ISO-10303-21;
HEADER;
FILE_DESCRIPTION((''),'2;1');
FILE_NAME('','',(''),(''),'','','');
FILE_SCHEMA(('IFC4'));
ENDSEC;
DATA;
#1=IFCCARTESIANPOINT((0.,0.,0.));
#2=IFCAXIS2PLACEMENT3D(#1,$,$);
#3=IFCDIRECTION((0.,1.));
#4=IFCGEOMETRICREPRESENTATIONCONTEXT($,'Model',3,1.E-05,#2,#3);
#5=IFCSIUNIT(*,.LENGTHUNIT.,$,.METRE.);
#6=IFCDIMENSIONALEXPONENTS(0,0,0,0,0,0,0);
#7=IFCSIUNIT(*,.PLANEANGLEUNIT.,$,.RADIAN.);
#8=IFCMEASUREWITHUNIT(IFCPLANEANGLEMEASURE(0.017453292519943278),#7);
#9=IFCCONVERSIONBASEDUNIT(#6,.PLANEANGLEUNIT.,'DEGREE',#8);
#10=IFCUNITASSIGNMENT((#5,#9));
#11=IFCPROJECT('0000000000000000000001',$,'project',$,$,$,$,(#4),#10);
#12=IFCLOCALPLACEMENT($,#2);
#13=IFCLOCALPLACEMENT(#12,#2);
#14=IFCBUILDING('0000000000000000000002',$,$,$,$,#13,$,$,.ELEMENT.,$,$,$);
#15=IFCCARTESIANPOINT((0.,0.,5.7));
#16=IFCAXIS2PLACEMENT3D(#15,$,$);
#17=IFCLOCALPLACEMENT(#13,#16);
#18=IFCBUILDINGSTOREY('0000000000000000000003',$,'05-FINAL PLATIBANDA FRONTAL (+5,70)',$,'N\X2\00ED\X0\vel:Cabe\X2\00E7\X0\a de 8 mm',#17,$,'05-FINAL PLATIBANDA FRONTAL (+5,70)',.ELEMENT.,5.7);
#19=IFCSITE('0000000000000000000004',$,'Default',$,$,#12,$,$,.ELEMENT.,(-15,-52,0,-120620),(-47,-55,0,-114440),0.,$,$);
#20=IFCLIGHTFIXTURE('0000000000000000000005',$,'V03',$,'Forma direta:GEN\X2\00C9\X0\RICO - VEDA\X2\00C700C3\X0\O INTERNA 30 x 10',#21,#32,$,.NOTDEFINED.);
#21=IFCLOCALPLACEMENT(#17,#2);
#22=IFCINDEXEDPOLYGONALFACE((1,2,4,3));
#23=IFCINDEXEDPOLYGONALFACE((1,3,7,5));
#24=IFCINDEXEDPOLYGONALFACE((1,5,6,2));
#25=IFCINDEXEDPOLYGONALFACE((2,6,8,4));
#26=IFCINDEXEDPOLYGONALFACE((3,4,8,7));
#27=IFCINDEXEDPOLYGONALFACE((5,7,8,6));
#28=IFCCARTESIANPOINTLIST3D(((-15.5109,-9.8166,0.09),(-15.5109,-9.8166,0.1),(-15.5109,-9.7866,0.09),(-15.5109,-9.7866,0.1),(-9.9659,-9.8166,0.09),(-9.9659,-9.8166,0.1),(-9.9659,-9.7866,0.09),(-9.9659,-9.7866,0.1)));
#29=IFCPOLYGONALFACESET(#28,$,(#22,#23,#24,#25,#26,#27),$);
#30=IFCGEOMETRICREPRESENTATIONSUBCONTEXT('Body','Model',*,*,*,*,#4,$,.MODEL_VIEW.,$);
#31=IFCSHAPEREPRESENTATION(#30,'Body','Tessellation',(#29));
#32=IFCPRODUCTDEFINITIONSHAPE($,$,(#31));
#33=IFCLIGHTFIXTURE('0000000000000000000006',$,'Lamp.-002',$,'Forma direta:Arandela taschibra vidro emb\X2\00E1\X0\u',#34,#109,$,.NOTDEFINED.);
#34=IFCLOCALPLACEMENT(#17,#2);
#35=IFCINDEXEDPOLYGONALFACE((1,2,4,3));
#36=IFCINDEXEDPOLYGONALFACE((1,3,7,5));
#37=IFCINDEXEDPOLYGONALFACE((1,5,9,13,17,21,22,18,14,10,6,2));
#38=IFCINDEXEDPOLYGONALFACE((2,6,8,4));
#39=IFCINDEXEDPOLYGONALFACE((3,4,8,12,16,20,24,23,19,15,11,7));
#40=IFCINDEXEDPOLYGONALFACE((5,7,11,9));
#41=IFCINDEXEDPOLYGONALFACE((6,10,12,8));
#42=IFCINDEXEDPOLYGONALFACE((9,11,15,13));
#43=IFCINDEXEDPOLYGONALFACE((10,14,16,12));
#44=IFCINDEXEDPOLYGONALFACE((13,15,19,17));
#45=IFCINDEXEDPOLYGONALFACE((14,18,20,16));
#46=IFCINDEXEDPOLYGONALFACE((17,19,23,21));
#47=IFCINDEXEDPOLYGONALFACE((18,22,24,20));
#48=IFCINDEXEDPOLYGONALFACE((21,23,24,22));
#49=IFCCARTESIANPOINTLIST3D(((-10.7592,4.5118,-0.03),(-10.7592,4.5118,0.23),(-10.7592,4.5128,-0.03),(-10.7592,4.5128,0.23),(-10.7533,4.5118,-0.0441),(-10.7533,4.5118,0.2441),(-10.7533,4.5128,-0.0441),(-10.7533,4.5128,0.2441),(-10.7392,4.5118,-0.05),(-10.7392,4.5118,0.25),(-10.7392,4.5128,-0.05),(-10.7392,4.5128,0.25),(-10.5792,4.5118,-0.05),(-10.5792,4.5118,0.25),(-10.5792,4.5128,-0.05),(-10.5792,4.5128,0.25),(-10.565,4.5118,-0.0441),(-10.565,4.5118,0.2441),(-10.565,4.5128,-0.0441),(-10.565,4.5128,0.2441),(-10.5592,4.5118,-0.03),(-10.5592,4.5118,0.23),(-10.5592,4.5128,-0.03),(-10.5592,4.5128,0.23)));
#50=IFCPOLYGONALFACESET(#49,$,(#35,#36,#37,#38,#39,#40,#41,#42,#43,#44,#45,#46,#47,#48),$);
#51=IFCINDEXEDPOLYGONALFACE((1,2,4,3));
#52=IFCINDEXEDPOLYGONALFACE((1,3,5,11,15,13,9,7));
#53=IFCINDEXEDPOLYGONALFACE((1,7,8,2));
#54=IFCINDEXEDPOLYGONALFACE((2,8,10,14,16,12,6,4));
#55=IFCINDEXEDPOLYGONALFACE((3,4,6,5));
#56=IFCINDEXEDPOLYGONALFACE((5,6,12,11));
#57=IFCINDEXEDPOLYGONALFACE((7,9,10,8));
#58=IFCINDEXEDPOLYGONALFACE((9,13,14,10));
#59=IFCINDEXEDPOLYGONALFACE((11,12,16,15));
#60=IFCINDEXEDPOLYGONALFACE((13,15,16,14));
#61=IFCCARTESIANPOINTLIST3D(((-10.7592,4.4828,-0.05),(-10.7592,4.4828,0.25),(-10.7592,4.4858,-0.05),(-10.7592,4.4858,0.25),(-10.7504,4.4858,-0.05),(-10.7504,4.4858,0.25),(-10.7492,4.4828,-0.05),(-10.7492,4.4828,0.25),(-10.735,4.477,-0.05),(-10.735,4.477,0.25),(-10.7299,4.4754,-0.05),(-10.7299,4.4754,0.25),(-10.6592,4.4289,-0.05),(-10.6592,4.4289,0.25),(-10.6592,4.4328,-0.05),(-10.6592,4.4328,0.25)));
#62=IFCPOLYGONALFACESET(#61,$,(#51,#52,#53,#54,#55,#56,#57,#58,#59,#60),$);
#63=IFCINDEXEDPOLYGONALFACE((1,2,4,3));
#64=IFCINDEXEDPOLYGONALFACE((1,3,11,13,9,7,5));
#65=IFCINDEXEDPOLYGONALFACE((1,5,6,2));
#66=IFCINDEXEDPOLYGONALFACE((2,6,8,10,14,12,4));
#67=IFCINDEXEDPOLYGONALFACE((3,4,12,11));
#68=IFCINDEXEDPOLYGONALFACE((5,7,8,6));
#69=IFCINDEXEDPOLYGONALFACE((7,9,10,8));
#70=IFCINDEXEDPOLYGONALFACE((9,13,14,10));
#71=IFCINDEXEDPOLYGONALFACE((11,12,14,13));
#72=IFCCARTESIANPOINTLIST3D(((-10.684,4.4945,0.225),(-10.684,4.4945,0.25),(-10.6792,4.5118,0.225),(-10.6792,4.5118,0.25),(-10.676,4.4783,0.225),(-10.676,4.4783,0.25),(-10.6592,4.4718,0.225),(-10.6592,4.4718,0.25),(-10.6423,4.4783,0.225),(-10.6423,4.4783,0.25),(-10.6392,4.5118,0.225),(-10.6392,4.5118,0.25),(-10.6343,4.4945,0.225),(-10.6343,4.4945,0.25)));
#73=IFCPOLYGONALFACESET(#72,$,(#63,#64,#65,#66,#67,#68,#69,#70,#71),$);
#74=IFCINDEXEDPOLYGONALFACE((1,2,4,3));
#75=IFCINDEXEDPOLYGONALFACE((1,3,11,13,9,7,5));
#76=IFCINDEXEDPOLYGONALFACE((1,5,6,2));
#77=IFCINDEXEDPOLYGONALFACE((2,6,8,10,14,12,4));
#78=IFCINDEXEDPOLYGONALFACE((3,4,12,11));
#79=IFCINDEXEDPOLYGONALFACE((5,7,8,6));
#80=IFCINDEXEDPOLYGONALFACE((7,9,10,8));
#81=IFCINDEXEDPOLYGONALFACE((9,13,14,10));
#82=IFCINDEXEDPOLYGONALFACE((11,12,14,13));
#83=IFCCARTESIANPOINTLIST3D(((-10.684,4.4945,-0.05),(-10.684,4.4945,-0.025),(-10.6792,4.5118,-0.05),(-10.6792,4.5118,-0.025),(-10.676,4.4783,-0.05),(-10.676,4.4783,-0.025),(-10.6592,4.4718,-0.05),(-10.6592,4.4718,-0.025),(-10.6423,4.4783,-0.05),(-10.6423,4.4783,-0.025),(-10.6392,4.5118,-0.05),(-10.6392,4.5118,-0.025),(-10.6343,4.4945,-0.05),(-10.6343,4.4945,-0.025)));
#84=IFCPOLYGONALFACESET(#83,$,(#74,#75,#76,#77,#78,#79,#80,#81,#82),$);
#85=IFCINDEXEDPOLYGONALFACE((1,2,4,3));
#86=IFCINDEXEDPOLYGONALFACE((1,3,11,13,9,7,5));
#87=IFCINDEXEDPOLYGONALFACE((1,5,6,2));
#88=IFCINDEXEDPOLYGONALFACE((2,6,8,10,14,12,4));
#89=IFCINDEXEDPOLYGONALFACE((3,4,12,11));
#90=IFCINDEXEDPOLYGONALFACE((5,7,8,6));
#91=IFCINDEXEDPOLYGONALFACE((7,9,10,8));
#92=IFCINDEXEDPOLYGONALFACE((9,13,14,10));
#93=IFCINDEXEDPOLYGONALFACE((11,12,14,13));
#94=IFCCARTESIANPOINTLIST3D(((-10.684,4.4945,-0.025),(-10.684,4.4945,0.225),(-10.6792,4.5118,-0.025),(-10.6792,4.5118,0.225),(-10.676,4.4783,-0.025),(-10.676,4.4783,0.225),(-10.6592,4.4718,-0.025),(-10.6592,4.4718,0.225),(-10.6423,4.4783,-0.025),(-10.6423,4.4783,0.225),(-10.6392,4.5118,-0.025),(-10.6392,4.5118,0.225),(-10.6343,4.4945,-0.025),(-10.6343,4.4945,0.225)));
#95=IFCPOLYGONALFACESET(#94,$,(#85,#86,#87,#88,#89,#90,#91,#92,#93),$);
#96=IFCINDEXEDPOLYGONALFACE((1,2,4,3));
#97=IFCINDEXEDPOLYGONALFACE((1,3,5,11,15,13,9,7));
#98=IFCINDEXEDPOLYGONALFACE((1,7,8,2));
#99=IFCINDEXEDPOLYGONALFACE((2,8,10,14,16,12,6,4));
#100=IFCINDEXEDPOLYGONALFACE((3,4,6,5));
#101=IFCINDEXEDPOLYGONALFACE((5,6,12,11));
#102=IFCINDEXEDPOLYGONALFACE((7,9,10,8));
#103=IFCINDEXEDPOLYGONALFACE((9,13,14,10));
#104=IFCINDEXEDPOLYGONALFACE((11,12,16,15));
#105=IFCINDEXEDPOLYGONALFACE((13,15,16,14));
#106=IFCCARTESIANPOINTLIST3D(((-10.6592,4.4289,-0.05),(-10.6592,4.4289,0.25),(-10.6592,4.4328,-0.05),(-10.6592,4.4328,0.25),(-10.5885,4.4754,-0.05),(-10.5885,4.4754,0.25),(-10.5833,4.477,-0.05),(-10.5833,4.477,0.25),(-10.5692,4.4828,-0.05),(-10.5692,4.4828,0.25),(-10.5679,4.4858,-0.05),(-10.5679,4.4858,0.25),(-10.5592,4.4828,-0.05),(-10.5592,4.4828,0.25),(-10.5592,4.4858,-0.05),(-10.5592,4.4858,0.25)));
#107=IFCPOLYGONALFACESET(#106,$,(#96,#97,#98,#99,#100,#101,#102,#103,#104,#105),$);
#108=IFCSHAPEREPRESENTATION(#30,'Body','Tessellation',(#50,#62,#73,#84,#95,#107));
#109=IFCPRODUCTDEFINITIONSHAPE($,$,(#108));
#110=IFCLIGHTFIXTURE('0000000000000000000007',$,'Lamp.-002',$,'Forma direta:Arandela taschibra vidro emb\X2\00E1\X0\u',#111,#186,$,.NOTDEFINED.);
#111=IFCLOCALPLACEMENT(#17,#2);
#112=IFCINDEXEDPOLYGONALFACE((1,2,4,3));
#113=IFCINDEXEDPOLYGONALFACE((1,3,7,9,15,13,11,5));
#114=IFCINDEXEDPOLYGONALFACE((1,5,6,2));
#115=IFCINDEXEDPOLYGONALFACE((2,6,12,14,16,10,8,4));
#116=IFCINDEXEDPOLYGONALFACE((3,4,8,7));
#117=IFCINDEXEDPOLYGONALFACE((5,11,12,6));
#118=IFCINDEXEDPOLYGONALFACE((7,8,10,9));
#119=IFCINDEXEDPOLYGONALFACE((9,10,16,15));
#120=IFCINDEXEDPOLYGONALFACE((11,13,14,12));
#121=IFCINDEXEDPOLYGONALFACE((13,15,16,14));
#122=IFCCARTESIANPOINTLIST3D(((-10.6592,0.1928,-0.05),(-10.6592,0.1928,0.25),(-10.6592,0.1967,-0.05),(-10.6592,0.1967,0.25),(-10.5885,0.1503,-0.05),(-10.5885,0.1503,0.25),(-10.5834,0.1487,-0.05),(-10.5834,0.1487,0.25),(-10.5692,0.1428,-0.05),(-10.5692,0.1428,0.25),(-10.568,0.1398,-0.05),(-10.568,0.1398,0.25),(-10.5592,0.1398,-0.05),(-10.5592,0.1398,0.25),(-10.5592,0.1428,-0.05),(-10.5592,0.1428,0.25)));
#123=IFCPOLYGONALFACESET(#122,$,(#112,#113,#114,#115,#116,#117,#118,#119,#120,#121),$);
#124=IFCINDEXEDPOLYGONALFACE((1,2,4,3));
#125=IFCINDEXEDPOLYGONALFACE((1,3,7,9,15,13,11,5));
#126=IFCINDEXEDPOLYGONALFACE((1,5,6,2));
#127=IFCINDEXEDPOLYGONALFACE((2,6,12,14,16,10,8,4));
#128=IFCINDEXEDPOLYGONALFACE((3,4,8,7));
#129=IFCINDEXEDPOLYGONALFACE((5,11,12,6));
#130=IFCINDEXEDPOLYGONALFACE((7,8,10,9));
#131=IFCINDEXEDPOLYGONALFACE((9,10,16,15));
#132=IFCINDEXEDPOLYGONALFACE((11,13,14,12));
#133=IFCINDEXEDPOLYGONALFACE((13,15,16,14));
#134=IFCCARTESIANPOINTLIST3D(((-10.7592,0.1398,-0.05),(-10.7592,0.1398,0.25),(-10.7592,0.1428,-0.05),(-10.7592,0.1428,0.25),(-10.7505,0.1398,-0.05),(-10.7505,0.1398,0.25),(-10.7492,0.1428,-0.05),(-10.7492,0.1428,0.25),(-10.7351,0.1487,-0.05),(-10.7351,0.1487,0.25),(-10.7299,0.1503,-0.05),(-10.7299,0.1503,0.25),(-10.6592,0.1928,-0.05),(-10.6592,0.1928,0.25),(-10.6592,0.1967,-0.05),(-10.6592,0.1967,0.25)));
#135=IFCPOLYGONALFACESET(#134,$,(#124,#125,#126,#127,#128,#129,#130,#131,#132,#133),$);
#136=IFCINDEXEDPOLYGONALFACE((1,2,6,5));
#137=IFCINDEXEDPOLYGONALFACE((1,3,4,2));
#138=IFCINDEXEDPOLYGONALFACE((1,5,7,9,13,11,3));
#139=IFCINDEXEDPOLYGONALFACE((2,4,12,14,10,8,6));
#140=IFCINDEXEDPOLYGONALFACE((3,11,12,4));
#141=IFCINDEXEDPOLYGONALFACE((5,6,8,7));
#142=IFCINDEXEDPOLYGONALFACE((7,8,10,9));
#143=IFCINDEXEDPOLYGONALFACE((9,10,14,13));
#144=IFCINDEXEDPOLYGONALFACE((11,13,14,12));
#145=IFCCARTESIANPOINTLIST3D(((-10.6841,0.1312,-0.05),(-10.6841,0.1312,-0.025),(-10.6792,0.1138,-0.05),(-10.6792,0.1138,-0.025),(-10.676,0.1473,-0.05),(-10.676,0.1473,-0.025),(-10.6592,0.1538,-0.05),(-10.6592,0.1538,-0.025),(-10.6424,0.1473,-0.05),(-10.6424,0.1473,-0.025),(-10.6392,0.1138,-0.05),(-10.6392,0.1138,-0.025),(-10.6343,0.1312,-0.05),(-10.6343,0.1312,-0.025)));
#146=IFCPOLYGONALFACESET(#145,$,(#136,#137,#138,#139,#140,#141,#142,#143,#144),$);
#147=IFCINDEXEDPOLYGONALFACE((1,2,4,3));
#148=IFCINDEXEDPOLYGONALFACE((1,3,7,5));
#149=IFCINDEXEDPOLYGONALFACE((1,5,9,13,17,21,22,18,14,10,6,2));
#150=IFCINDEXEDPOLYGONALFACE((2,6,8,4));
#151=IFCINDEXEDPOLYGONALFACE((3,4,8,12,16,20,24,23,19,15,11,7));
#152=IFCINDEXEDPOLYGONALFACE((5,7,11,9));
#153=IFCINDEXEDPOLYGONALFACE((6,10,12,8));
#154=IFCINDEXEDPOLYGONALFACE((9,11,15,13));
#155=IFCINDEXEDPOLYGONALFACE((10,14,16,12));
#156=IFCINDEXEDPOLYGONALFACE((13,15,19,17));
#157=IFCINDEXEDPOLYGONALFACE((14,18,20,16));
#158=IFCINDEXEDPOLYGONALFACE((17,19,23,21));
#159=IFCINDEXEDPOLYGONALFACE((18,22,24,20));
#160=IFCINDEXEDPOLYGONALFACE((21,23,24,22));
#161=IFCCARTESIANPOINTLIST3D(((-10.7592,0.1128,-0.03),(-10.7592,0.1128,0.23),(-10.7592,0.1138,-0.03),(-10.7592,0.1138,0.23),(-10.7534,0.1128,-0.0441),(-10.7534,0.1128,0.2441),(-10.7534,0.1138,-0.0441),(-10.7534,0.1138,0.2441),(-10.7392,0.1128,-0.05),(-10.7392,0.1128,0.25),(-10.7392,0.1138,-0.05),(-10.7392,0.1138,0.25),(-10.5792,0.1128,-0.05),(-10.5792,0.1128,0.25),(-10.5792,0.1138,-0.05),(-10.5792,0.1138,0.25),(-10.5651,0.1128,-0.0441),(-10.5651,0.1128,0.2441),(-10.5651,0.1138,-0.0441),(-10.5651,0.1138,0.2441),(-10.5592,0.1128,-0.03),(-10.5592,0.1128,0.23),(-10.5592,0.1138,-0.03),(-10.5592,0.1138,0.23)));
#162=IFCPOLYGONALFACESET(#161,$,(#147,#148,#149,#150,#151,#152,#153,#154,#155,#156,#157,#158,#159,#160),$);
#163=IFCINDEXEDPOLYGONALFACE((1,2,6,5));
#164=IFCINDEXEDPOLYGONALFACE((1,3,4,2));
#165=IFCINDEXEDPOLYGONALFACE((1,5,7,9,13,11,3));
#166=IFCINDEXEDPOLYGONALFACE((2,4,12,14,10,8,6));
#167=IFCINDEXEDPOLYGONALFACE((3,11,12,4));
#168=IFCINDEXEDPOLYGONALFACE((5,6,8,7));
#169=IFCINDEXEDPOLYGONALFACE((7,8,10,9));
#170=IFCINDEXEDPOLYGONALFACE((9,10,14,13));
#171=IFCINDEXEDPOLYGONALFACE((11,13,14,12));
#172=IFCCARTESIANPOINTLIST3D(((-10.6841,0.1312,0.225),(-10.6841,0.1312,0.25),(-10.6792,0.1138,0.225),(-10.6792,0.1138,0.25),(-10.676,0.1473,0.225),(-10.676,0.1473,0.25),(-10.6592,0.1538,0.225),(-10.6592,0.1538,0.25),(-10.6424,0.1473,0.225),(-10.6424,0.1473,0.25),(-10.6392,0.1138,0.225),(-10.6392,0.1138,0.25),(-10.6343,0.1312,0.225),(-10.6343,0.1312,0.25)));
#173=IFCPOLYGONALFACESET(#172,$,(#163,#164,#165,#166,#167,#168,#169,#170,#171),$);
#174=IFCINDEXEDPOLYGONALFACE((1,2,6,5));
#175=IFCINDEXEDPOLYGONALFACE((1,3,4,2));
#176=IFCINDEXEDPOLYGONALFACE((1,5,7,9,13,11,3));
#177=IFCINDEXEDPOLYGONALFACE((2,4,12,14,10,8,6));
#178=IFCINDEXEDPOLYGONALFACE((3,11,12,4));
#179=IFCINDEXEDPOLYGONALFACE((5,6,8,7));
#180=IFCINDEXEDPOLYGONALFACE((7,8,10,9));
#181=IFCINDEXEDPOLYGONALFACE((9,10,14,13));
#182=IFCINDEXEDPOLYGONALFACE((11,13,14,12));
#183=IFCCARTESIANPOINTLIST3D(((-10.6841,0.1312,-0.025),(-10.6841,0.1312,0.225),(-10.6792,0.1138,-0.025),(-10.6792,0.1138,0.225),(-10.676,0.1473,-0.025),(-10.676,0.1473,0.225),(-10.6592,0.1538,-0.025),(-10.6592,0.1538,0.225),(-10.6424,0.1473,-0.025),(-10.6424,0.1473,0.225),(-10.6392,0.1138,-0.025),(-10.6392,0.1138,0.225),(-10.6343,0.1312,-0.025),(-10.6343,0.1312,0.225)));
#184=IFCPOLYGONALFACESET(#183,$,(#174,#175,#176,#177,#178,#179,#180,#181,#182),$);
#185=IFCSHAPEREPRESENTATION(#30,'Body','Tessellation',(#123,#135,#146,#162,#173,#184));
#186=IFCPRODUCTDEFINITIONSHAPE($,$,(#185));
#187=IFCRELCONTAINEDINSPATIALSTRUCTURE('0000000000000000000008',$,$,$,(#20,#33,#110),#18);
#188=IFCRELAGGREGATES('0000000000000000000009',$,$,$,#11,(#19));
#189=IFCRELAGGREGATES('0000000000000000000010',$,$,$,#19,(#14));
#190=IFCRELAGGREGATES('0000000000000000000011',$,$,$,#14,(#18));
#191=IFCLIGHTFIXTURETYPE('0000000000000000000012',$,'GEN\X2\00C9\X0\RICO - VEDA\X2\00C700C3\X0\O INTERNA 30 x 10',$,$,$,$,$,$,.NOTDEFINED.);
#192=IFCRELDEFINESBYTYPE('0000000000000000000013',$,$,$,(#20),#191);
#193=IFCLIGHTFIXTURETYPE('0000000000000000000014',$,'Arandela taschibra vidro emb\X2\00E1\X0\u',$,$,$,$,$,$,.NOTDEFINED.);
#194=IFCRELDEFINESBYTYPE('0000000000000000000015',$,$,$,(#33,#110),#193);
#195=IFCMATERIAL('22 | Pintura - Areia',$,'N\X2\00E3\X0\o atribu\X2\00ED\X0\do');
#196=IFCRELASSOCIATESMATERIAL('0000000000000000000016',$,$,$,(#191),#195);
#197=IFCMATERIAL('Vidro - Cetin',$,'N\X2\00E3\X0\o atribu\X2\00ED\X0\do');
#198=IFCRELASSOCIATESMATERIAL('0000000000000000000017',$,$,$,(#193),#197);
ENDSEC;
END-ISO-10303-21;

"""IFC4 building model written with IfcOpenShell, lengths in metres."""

from ifc_helpers import new_model, entity, si_unit, converted_unit, direction, frame, origin, place, context, subcontext, project, spatial, indexed_curve, outline, extrude, material, type_object, element, save


model = new_model("IFC4")

# Units and contexts
model_context = context("Model", 3, precision=1e-05, world=origin(), true_north=direction((0.0, 1.0)))
body_context = subcontext(model_context, "Body", "Model", "MODEL_VIEW")
ifc_project = project(units=[si_unit("LENGTHUNIT", "METRE"), converted_unit("PLANEANGLEUNIT", "DEGREE", entity("IfcPlaneAngleMeasure", 0.017453292519943278), si_unit("PLANEANGLEUNIT", "RADIAN"), dimensions=[0, 0, 0, 0, 0, 0, 0])], contexts=[model_context])

# Site, building, storey
site_placement = place(None, origin())
site = spatial("IfcSite", under=ifc_project, at=site_placement, Name="Default", CompositionType="ELEMENT", RefLatitude=(-15, -52, 0, -120620), RefLongitude=(-47, -55, 0, -114440), RefElevation=0.0)
building_placement = place(site_placement, origin())
building = spatial("IfcBuilding", under=site, at=building_placement, CompositionType="ELEMENT")
storey_placement = place(building_placement, frame((0.0, 0.0, 5.7)))
storey = spatial("IfcBuildingStorey", under=building, at=storey_placement, Name="05-FINAL PLATIBANDA FRONTAL (+5,70)", ObjectType="Nível:Cabeça de 8 mm", LongName="05-FINAL PLATIBANDA FRONTAL (+5,70)", CompositionType="ELEMENT", Elevation=5.7)

# Light fixtures
ifc_material_1 = material(Name="22 | Pintura - Areia", Category="Não atribuído")
light_fixture_type_1 = type_object("IfcLightFixtureType", Name="GENÉRICO - VEDAÇÃO INTERNA 30 x 10", PredefinedType="NOTDEFINED", material=ifc_material_1)
light_fixture_1_placement = place(storey_placement, origin())
element("IfcLightFixture", 1, at=light_fixture_1_placement, inside=storey, type_object=light_fixture_type_1, Name="V03", ObjectType="Forma direta:GENÉRICO - VEDAÇÃO INTERNA 30 x 10", PredefinedType="NOTDEFINED", context=body_context, shape_type="SweptSolid", body=[
    extrude(outline(indexed_curve([(-2.7725, -0.015), (2.7725, -0.015), (2.7725, 0.015), (-2.7725, 0.015), (-2.7725, -0.015)], self_intersect=False)), frame((-12.7384, -9.8016, 0.09)), (0.0, 0.0, 1.0), 0.01),
])
ifc_material_2 = material(Name="Vidro - Cetin", Category="Não atribuído")
light_fixture_type_2 = type_object("IfcLightFixtureType", Name="Arandela taschibra vidro embáu", PredefinedType="NOTDEFINED", material=ifc_material_2)
light_fixture_2_placement = place(storey_placement, origin())
element("IfcLightFixture", 2, at=light_fixture_2_placement, inside=storey, type_object=light_fixture_type_2, Name="Lamp.-002", ObjectType="Forma direta:Arandela taschibra vidro embáu", PredefinedType="NOTDEFINED", context=body_context, shape_type="SweptSolid", body=[
    extrude(outline(indexed_curve([(-0.08, -0.15), (0.08, -0.15), (0.0941, -0.1441), (0.1, -0.13), (0.1, 0.13), (0.0941, 0.1441), (0.08, 0.15), (-0.08, 0.15), (-0.0941, 0.1441), (-0.1, 0.13), (-0.1, -0.13), (-0.0941, -0.1441), (-0.08, -0.15)], self_intersect=False)), frame((-10.6592, 4.5118, 0.1), z_axis=(0.000013, 1.0, 0.0), x_axis=(-1.0, 0.000013, 0.0)), (0.0, 0.0, 1.0), 0.001),
    extrude(outline(indexed_curve([(-0.0169, -0.034), (-0.0139, -0.034), (-0.0139, -0.024), (-0.008, -0.0099), (0.04, 0.066), (0.0361, 0.066), (-0.0065, -0.0047), (-0.0169, -0.0253), (-0.0169, -0.034)], self_intersect=False)), frame((-10.7251, 4.4689, -0.05), z_axis=(0.0, 0.0, 1.0), x_axis=(-0.000013, -1.0, 0.0)), (0.0, 0.0, 1.0), 0.3),
    extrude(outline(indexed_curve([(-0.0141, -0.0247), (0.004, -0.0247), (0.0173, -0.0126), (0.019, 0.0054), (0.0082, 0.0198), (-0.0095, 0.0232), (-0.0249, 0.0138), (-0.0141, -0.0247)], self_intersect=False)), frame((-10.6592, 4.4916, 0.225), z_axis=(0.0, 0.0, 1.0), x_axis=(-0.271031, -0.96257, 0.0)), (0.0, 0.0, 1.0), 0.025),
    extrude(outline(indexed_curve([(-0.0141, -0.0247), (0.004, -0.0247), (0.0173, -0.0126), (0.019, 0.0054), (0.0082, 0.0198), (-0.0095, 0.0232), (-0.0249, 0.0138), (-0.0141, -0.0247)], self_intersect=False)), frame((-10.6592, 4.4916, -0.05), z_axis=(0.0, 0.0, 1.0), x_axis=(-0.271031, -0.96257, 0.0)), (0.0, 0.0, 1.0), 0.025),
    extrude(outline(indexed_curve([(-0.0141, -0.0247), (0.004, -0.0247), (0.0173, -0.0126), (0.019, 0.0054), (0.0082, 0.0198), (-0.0095, 0.0232), (-0.0249, 0.0138), (-0.0141, -0.0247)], self_intersect=False)), frame((-10.6592, 4.4916, -0.025), z_axis=(0.0, 0.0, 1.0), x_axis=(-0.271031, -0.96257, 0.0)), (0.0, 0.0, 1.0), 0.25),
    extrude(outline(indexed_curve([(-0.034, -0.0169), (-0.0253, -0.0169), (-0.0047, -0.0065), (0.066, 0.0361), (0.066, 0.04), (-0.0099, -0.008), (-0.024, -0.0139), (-0.034, -0.0139), (-0.034, -0.0169)], self_intersect=False)), frame((-10.5932, 4.4689, -0.05), z_axis=(0.0, 0.0, 1.0), x_axis=(-1.0, -0.000426, 0.0)), (0.0, 0.0, 1.0), 0.3),
])
light_fixture_3_placement = place(storey_placement, origin())
element("IfcLightFixture", 3, at=light_fixture_3_placement, inside=storey, type_object=light_fixture_type_2, Name="Lamp.-002", ObjectType="Forma direta:Arandela taschibra vidro embáu", PredefinedType="NOTDEFINED", context=body_context, shape_type="SweptSolid", body=[
    extrude(outline(indexed_curve([(-0.0169, -0.034), (-0.0139, -0.034), (-0.0139, -0.024), (-0.008, -0.0099), (0.04, 0.066), (0.0361, 0.066), (-0.0065, -0.0047), (-0.0169, -0.0253), (-0.0169, -0.034)], self_intersect=False)), frame((-10.5932, 0.1567, -0.05), z_axis=(0.0, 0.0, 1.0), x_axis=(0.000013, 1.0, 0.0)), (0.0, 0.0, 1.0), 0.3),
    extrude(outline(indexed_curve([(-0.034, -0.0169), (-0.0253, -0.0169), (-0.0047, -0.0065), (0.066, 0.0361), (0.066, 0.04), (-0.0099, -0.008), (-0.024, -0.0139), (-0.034, -0.0139), (-0.034, -0.0169)], self_intersect=False)), frame((-10.7252, 0.1567, -0.05), z_axis=(0.0, 0.0, 1.0), x_axis=(1.0, 0.000426, 0.0)), (0.0, 0.0, 1.0), 0.3),
    extrude(outline(indexed_curve([(-0.02, -0.0202), (0.02, -0.0202), (0.0249, -0.0029), (0.0168, 0.0132), (0.0, 0.0198), (-0.0168, 0.0132), (-0.0249, -0.0029), (-0.02, -0.0202)], self_intersect=False)), frame((-10.6592, 0.1341, -0.05)), (0.0, 0.0, 1.0), 0.025),
    extrude(outline(indexed_curve([(-0.08, -0.15), (0.08, -0.15), (0.0941, -0.1441), (0.1, -0.13), (0.1, 0.13), (0.0941, 0.1441), (0.08, 0.15), (-0.08, 0.15), (-0.0941, 0.1441), (-0.1, 0.13), (-0.1, -0.13), (-0.0941, -0.1441), (-0.08, -0.15)], self_intersect=False)), frame((-10.6592, 0.1128, 0.1), z_axis=(0.000013, 1.0, 0.0), x_axis=(-1.0, 0.000013, 0.0)), (0.0, 0.0, 1.0), 0.001),
    extrude(outline(indexed_curve([(-0.02, -0.0202), (0.02, -0.0202), (0.0249, -0.0029), (0.0168, 0.0132), (0.0, 0.0198), (-0.0168, 0.0132), (-0.0249, -0.0029), (-0.02, -0.0202)], self_intersect=False)), frame((-10.6592, 0.1341, 0.225)), (0.0, 0.0, 1.0), 0.025),
    extrude(outline(indexed_curve([(-0.02, -0.0202), (0.02, -0.0202), (0.0249, -0.0029), (0.0168, 0.0132), (0.0, 0.0198), (-0.0168, 0.0132), (-0.0249, -0.0029), (-0.02, -0.0202)], self_intersect=False)), frame((-10.6592, 0.1341, -0.025)), (0.0, 0.0, 1.0), 0.25),
])

save(model, "model.ifc")
